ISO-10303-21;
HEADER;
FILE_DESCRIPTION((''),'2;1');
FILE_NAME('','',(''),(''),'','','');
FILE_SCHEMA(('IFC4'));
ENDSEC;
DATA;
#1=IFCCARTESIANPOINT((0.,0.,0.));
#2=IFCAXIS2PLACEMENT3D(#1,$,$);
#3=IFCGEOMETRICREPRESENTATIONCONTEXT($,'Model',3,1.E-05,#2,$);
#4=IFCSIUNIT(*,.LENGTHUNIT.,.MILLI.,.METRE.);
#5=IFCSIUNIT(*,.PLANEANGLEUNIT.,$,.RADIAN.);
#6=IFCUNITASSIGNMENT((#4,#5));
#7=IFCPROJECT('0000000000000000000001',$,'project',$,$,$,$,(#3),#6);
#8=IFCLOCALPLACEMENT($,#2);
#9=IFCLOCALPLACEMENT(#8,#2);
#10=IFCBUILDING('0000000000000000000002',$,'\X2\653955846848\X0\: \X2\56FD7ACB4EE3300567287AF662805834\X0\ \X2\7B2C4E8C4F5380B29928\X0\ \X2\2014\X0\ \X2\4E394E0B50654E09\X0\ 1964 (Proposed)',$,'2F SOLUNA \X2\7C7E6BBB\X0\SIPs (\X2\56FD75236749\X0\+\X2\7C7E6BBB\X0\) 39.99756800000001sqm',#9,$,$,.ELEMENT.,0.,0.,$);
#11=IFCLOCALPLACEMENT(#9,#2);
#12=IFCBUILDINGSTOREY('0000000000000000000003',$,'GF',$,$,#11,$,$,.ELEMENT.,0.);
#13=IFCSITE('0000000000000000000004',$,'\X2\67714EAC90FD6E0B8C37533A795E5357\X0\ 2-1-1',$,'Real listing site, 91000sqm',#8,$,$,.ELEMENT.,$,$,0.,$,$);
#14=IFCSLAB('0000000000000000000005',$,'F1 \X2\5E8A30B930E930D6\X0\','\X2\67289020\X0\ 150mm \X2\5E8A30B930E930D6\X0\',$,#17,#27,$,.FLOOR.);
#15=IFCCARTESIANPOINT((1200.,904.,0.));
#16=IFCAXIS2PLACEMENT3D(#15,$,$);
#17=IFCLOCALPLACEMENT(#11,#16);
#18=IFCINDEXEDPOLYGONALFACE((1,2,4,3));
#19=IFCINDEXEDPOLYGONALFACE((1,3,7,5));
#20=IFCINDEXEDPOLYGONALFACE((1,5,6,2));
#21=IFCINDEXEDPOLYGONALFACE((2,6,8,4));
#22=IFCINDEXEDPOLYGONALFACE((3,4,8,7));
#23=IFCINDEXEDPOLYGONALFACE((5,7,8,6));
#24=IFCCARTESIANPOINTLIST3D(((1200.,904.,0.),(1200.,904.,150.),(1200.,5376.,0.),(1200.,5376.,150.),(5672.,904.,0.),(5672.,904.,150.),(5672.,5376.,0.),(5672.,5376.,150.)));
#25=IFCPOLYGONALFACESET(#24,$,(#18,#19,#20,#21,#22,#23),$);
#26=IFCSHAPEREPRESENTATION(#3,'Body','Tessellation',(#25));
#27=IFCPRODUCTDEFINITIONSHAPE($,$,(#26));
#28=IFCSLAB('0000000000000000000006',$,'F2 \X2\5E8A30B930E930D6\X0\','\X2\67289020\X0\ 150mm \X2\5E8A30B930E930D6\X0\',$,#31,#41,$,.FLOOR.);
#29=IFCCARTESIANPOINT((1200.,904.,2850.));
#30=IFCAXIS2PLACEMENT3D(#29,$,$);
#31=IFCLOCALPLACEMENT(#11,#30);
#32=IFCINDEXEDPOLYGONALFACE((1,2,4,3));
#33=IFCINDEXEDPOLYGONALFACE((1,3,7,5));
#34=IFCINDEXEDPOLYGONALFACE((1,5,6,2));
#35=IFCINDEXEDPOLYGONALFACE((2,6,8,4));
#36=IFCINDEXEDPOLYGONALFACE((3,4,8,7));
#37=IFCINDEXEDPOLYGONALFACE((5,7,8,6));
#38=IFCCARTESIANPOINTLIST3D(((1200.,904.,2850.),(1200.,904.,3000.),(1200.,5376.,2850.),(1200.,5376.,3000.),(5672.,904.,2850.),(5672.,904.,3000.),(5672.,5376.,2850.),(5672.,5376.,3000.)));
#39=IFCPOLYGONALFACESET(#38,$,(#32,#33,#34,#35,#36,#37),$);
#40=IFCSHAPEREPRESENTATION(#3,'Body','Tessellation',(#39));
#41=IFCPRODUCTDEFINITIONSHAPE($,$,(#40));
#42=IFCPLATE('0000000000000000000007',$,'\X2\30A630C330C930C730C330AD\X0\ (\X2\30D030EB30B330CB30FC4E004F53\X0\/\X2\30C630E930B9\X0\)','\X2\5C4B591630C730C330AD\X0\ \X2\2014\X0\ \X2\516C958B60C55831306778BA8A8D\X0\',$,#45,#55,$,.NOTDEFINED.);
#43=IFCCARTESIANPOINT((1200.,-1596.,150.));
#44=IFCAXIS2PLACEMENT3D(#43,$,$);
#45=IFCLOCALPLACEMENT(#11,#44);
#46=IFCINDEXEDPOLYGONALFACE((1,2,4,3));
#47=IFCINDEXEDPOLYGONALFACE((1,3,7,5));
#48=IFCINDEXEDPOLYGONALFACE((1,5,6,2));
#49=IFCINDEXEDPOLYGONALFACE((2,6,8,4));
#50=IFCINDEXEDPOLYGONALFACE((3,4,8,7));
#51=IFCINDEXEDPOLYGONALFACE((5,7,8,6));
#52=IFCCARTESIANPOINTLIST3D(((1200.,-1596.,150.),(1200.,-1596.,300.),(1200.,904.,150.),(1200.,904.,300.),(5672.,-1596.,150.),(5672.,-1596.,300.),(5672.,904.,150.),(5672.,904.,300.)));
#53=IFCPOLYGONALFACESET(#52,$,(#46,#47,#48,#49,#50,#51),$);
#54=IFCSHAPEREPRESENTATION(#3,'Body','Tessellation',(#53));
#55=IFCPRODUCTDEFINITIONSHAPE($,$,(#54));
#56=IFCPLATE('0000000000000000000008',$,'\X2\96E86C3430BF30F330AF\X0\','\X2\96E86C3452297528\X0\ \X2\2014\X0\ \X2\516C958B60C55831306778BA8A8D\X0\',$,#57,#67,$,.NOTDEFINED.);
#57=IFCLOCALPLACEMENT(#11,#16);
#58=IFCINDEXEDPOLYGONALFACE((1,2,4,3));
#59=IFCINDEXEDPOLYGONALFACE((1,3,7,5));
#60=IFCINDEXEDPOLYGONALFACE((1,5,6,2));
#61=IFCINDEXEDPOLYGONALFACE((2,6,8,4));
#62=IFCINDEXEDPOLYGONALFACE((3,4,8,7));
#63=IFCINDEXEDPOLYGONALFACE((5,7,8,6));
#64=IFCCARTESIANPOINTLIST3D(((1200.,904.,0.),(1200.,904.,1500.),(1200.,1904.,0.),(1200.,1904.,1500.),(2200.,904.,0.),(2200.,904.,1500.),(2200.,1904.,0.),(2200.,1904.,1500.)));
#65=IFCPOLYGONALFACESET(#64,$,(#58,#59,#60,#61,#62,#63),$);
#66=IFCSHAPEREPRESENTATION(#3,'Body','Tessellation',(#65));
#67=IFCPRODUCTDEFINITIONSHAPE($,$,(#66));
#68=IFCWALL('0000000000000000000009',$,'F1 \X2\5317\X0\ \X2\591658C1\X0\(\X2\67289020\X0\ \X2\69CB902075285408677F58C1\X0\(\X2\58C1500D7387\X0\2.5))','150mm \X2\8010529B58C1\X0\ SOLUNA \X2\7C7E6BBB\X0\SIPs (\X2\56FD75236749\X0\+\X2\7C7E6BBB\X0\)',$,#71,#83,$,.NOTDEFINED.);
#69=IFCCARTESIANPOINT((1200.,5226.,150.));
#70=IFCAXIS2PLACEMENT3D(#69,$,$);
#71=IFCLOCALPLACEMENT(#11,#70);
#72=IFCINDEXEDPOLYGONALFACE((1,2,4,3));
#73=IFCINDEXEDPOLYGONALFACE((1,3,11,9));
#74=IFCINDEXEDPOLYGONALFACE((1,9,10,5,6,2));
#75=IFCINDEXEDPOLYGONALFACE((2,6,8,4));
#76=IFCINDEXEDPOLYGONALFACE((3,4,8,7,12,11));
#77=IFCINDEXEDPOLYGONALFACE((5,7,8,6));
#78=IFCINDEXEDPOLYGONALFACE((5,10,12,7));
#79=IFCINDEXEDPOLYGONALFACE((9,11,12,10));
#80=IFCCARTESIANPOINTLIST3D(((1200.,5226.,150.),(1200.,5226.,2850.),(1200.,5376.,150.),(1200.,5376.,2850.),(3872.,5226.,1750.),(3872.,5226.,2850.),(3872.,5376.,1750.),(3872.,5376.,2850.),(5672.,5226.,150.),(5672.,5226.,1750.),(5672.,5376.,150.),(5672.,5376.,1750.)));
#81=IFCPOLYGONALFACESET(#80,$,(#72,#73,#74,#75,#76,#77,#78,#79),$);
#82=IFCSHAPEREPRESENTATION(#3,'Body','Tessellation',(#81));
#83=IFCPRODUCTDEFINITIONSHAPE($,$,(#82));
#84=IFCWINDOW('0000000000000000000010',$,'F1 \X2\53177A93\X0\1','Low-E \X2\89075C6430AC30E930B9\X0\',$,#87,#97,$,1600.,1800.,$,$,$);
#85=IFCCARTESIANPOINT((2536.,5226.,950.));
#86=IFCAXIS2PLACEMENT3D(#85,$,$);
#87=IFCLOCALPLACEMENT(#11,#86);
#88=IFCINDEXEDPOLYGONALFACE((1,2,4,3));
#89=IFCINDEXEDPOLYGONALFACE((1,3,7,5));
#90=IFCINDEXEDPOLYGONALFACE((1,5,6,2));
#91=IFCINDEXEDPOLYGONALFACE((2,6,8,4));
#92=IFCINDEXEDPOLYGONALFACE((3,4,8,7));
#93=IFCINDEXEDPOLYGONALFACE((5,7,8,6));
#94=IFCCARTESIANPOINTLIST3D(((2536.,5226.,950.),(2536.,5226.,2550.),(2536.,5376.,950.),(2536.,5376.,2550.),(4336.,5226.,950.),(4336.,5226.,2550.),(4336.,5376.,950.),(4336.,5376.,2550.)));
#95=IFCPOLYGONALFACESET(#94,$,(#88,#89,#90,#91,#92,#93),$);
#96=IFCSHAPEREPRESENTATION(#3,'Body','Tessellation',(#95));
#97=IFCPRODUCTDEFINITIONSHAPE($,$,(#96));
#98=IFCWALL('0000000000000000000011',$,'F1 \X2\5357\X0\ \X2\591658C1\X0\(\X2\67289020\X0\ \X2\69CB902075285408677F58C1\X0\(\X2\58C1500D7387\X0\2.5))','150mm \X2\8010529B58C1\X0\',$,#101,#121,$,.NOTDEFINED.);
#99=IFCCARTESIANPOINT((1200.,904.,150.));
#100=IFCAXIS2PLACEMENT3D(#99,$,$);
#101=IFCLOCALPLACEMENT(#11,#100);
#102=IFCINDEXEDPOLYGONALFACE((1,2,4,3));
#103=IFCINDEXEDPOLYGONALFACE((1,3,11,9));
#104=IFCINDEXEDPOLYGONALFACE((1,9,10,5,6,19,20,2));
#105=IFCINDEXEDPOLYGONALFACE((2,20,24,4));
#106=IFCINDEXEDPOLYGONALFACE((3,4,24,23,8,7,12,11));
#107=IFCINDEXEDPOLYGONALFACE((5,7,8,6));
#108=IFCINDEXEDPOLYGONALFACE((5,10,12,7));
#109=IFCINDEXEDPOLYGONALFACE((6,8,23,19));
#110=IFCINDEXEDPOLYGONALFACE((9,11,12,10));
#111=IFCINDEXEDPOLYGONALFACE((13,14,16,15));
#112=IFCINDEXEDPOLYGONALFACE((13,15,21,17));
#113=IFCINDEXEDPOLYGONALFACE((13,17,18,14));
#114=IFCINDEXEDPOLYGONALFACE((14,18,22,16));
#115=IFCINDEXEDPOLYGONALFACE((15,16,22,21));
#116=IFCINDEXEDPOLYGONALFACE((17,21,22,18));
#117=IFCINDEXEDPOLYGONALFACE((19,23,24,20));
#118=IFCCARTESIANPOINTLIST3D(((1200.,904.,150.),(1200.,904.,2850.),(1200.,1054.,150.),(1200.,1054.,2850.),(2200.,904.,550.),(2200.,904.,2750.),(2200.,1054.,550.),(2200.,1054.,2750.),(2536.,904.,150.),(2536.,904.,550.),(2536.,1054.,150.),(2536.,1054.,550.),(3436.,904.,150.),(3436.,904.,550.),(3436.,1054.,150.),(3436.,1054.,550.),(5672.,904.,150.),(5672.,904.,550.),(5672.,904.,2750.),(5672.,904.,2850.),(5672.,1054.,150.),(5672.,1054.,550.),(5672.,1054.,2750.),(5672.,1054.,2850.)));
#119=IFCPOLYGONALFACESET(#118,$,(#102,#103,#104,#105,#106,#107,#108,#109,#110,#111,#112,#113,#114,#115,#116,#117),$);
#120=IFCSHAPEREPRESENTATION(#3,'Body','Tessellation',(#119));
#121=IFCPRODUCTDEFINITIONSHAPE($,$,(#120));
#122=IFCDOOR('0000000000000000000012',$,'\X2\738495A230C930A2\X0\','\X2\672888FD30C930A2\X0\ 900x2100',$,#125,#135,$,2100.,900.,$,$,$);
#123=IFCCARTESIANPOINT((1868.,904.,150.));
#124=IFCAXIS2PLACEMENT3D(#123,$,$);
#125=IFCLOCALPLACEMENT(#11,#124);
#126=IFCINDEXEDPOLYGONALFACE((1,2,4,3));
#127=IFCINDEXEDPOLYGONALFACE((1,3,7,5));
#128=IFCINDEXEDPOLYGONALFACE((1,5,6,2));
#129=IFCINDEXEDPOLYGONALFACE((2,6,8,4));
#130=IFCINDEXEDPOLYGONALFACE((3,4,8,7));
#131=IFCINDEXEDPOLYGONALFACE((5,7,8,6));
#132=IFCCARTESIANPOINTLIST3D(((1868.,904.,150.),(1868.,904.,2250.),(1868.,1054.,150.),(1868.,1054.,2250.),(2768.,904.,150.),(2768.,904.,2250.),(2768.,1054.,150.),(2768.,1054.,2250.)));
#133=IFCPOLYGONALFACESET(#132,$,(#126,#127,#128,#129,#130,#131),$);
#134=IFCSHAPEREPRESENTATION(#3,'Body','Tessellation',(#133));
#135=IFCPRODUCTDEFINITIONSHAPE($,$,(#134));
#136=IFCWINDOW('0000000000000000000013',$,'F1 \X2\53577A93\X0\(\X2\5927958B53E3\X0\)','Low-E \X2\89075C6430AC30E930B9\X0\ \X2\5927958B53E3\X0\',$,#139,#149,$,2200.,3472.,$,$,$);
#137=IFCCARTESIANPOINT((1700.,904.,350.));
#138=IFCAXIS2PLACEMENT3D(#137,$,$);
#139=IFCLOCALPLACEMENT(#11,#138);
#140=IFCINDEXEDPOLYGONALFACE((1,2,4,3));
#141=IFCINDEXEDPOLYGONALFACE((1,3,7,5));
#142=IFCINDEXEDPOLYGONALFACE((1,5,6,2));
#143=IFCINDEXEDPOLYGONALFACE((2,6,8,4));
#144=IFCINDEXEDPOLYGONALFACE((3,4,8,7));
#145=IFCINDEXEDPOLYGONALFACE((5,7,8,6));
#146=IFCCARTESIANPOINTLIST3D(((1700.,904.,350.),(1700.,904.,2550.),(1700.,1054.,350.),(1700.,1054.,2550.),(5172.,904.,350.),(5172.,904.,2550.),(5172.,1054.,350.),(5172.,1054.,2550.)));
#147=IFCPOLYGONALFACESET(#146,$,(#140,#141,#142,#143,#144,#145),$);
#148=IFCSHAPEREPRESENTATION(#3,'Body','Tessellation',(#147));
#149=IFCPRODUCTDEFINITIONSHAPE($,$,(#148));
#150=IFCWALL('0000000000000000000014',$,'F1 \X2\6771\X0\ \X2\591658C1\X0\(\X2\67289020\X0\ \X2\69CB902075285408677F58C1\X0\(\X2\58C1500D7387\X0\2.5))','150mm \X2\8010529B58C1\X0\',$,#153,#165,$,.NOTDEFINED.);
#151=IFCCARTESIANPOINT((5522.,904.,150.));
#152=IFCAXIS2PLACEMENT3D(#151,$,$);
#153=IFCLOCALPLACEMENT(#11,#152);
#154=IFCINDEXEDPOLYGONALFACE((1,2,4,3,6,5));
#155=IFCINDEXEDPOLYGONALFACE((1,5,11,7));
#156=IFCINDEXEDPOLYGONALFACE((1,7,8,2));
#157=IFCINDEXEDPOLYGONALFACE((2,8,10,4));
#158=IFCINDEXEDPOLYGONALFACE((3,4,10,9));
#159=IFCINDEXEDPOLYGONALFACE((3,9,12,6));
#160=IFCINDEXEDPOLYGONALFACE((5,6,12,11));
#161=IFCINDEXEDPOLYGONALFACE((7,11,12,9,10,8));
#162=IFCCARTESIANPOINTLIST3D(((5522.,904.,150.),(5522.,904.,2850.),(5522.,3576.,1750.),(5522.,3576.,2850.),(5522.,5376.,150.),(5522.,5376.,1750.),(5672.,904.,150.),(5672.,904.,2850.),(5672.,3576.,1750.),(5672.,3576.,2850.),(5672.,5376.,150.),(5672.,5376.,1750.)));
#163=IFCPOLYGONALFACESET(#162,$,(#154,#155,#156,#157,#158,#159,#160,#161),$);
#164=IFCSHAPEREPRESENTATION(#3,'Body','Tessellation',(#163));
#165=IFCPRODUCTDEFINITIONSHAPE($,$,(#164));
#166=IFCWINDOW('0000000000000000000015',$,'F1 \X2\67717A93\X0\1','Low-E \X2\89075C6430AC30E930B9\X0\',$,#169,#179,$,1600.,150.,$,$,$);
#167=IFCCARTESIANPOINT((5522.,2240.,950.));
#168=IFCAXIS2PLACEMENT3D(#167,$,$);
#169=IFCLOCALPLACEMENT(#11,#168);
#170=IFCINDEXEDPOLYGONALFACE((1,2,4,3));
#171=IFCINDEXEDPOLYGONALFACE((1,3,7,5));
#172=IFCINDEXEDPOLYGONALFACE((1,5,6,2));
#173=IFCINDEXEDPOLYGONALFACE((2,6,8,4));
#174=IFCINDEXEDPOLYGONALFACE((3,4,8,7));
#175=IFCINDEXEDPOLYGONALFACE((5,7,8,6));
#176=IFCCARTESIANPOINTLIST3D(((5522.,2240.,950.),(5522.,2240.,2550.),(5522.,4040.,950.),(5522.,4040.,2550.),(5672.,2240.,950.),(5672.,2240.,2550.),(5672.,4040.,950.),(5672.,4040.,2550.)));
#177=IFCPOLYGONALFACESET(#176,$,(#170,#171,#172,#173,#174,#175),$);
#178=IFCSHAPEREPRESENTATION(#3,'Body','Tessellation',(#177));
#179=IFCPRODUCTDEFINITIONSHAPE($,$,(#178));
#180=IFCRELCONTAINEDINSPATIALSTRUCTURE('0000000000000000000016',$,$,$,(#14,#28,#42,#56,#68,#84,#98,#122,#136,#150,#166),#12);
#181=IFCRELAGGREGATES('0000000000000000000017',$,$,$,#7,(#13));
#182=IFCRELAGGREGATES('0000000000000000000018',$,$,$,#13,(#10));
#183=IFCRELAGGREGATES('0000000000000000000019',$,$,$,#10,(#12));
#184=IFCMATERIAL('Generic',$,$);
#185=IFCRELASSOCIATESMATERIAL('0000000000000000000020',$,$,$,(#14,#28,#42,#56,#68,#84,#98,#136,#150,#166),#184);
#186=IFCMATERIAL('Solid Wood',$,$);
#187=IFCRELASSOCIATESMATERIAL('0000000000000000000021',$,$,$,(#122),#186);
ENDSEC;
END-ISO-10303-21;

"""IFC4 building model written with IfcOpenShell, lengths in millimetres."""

from ifc_helpers import new_model, si_unit, frame, frame_2d, origin, place, context, project, spatial, rectangle, extrude, material, element, fill, save


model = new_model("IFC4")

# Units and contexts
model_context = context("Model", 3, precision=1e-05, world=origin())
ifc_project = project(units=[si_unit("LENGTHUNIT", "METRE", prefix="MILLI"), si_unit("PLANEANGLEUNIT", "RADIAN")], contexts=[model_context])

# Site, building, storey
site_placement = place(None, origin())
site = spatial("IfcSite", under=ifc_project, at=site_placement, Name="東京都渋谷区神南 2-1-1", ObjectType="Real listing site, 91000sqm", CompositionType="ELEMENT", RefElevation=0.0)
building_placement = place(site_placement, origin())
building = spatial("IfcBuilding", under=site, at=building_placement, Name="改善案: 国立代々木競技場 第二体育館 — 丹下健三 1964 (Proposed)", ObjectType="2F SOLUNA 籾殻SIPs (国産杉+籾殻) 39.99756800000001sqm", CompositionType="ELEMENT", ElevationOfRefHeight=0.0, ElevationOfTerrain=0.0)
storey_placement = place(building_placement, origin())
storey = spatial("IfcBuildingStorey", under=building, at=storey_placement, Name="GF", CompositionType="ELEMENT", Elevation=0.0)

# Slabs
ifc_material_1 = material(Name="Generic")
slab_1_placement = place(storey_placement, frame((1200.0, 904.0, 0.0)))
element("IfcSlab", 1, at=slab_1_placement, inside=storey, material=ifc_material_1, Name="F1 床スラブ", Description="木造 150mm 床スラブ", PredefinedType="FLOOR", context=model_context, shape_type="SweptSolid", body=[
    extrude(rectangle(XDim=4472.0, YDim=4472.0, at=frame_2d((2236.0, 2236.0))), frame((1200.0, 904.0, 0.0)), (0.0, 0.0, 1.0), 150.0),
])
slab_2_placement = place(storey_placement, frame((1200.0, 904.0, 2850.0)))
element("IfcSlab", 2, at=slab_2_placement, inside=storey, material=ifc_material_1, Name="F2 床スラブ", Description="木造 150mm 床スラブ", PredefinedType="FLOOR", context=model_context, shape_type="SweptSolid", body=[
    extrude(rectangle(XDim=4472.0, YDim=4472.0, at=frame_2d((2236.0, 2236.0))), frame((1200.0, 904.0, 2850.0)), (0.0, 0.0, 1.0), 150.0),
])

# Plates
plate_1_placement = place(storey_placement, frame((1200.0, -1596.0, 150.0)))
element("IfcPlate", 3, at=plate_1_placement, inside=storey, material=ifc_material_1, Name="ウッドデッキ (バルコニー一体/テラス)", Description="屋外デッキ — 公開情報で確認", PredefinedType="NOTDEFINED", context=model_context, shape_type="SweptSolid", body=[
    extrude(rectangle(XDim=4472.0, YDim=2500.0, at=frame_2d((2236.0, 1250.0))), frame((1200.0, -1596.0, 150.0)), (0.0, 0.0, 1.0), 150.0),
])
plate_2_placement = place(storey_placement, frame((1200.0, 904.0, 0.0)))
element("IfcPlate", 4, at=plate_2_placement, inside=storey, material=ifc_material_1, Name="雨水タンク", Description="雨水利用 — 公開情報で確認", PredefinedType="NOTDEFINED", context=model_context, shape_type="SweptSolid", body=[
    extrude(rectangle(XDim=1000.0, YDim=1000.0, at=frame_2d((500.0, 500.0))), frame((1200.0, 904.0, 0.0)), (0.0, 0.0, 1.0), 1500.0),
])

# Wall, opening, window
wall_1_placement = place(storey_placement, frame((1200.0, 5226.0, 150.0)))
wall_1 = element("IfcWall", 5, at=wall_1_placement, inside=storey, material=ifc_material_1, Name="F1 北 外壁(木造 構造用合板壁(壁倍率2.5))", Description="150mm 耐力壁 SOLUNA 籾殻SIPs (国産杉+籾殻)", PredefinedType="NOTDEFINED", context=model_context, shape_type="SweptSolid", body=[
    extrude(rectangle(XDim=4472.0, YDim=150.0, at=frame_2d((2236.0, 75.0))), frame((1200.0, 5226.0, 150.0)), (0.0, 0.0, 1.0), 2700.0),
])
opening_1_placement = place(storey_placement, frame((2536.0, 5226.0, 950.0)))
opening_1 = element("IfcOpeningElement", 6, at=opening_1_placement, cuts=wall_1, PredefinedType="NOTDEFINED", context=model_context, shape_type="SweptSolid", body=[
    extrude(rectangle(XDim=1800.0, YDim=150.0, at=frame_2d((900.0, 75.0))), frame((2536.0, 5226.0, 950.0)), (0.0, 0.0, 1.0), 1600.0),
])
window_1_placement = place(storey_placement, frame((2536.0, 5226.0, 950.0)))
window_1 = element("IfcWindow", 7, at=window_1_placement, inside=storey, material=ifc_material_1, Name="F1 北窓1", Description="Low-E 複層ガラス", OverallHeight=1600.0, OverallWidth=1800.0, context=model_context, shape_type="SweptSolid", body=[
    extrude(rectangle(XDim=1800.0, YDim=150.0, at=frame_2d((900.0, 75.0))), frame((2536.0, 5226.0, 950.0)), (0.0, 0.0, 1.0), 1600.0),
])
fill(opening_1, window_1)

# Wall, openings, door, window
wall_2_placement = place(storey_placement, frame((1200.0, 904.0, 150.0)))
wall_2 = element("IfcWall", 8, at=wall_2_placement, inside=storey, material=ifc_material_1, Name="F1 南 外壁(木造 構造用合板壁(壁倍率2.5))", Description="150mm 耐力壁", PredefinedType="NOTDEFINED", context=model_context, shape_type="SweptSolid", body=[
    extrude(rectangle(XDim=4472.0, YDim=150.0, at=frame_2d((2236.0, 75.0))), frame((1200.0, 904.0, 150.0)), (0.0, 0.0, 1.0), 2700.0),
])
opening_2_placement = place(storey_placement, frame((1868.0, 904.0, 150.0)))
opening_2 = element("IfcOpeningElement", 9, at=opening_2_placement, cuts=wall_2, PredefinedType="NOTDEFINED", context=model_context, shape_type="SweptSolid", body=[
    extrude(rectangle(XDim=900.0, YDim=150.0, at=frame_2d((450.0, 75.0))), frame((1868.0, 904.0, 150.0)), (0.0, 0.0, 1.0), 2100.0),
])
opening_3_placement = place(storey_placement, frame((1700.0, 904.0, 350.0)))
opening_3 = element("IfcOpeningElement", 10, at=opening_3_placement, cuts=wall_2, PredefinedType="NOTDEFINED", context=model_context, shape_type="SweptSolid", body=[
    extrude(rectangle(XDim=3472.0, YDim=150.0, at=frame_2d((1736.0, 75.0))), frame((1700.0, 904.0, 350.0)), (0.0, 0.0, 1.0), 2200.0),
])
ifc_material_2 = material(Name="Solid Wood")
door_placement = place(storey_placement, frame((1868.0, 904.0, 150.0)))
door = element("IfcDoor", 11, at=door_placement, inside=storey, material=ifc_material_2, Name="玄関ドア", Description="木製ドア 900x2100", OverallHeight=2100.0, OverallWidth=900.0, context=model_context, shape_type="SweptSolid", body=[
    extrude(rectangle(XDim=900.0, YDim=150.0, at=frame_2d((450.0, 75.0))), frame((1868.0, 904.0, 150.0)), (0.0, 0.0, 1.0), 2100.0),
])
fill(opening_2, door)
window_2_placement = place(storey_placement, frame((1700.0, 904.0, 350.0)))
window_2 = element("IfcWindow", 12, at=window_2_placement, inside=storey, material=ifc_material_1, Name="F1 南窓(大開口)", Description="Low-E 複層ガラス 大開口", OverallHeight=2200.0, OverallWidth=3472.0, context=model_context, shape_type="SweptSolid", body=[
    extrude(rectangle(XDim=3472.0, YDim=150.0, at=frame_2d((1736.0, 75.0))), frame((1700.0, 904.0, 350.0)), (0.0, 0.0, 1.0), 2200.0),
])
fill(opening_3, window_2)

# Wall, opening, window
wall_3_placement = place(storey_placement, frame((5522.0, 904.0, 150.0)))
wall_3 = element("IfcWall", 13, at=wall_3_placement, inside=storey, material=ifc_material_1, Name="F1 東 外壁(木造 構造用合板壁(壁倍率2.5))", Description="150mm 耐力壁", PredefinedType="NOTDEFINED", context=model_context, shape_type="SweptSolid", body=[
    extrude(rectangle(XDim=150.0, YDim=4472.0, at=frame_2d((75.0, 2236.0))), frame((5522.0, 904.0, 150.0)), (0.0, 0.0, 1.0), 2700.0),
])
opening_4_placement = place(storey_placement, frame((5522.0, 2240.0, 950.0)))
opening_4 = element("IfcOpeningElement", 14, at=opening_4_placement, cuts=wall_3, PredefinedType="NOTDEFINED", context=model_context, shape_type="SweptSolid", body=[
    extrude(rectangle(XDim=150.0, YDim=1800.0, at=frame_2d((75.0, 900.0))), frame((5522.0, 2240.0, 950.0)), (0.0, 0.0, 1.0), 1600.0),
])
window_3_placement = place(storey_placement, frame((5522.0, 2240.0, 950.0)))
window_3 = element("IfcWindow", 15, at=window_3_placement, inside=storey, material=ifc_material_1, Name="F1 東窓1", Description="Low-E 複層ガラス", OverallHeight=1600.0, OverallWidth=150.0, context=model_context, shape_type="SweptSolid", body=[
    extrude(rectangle(XDim=150.0, YDim=1800.0, at=frame_2d((75.0, 900.0))), frame((5522.0, 2240.0, 950.0)), (0.0, 0.0, 1.0), 1600.0),
])
fill(opening_4, window_3)

save(model, "model.ifc")
